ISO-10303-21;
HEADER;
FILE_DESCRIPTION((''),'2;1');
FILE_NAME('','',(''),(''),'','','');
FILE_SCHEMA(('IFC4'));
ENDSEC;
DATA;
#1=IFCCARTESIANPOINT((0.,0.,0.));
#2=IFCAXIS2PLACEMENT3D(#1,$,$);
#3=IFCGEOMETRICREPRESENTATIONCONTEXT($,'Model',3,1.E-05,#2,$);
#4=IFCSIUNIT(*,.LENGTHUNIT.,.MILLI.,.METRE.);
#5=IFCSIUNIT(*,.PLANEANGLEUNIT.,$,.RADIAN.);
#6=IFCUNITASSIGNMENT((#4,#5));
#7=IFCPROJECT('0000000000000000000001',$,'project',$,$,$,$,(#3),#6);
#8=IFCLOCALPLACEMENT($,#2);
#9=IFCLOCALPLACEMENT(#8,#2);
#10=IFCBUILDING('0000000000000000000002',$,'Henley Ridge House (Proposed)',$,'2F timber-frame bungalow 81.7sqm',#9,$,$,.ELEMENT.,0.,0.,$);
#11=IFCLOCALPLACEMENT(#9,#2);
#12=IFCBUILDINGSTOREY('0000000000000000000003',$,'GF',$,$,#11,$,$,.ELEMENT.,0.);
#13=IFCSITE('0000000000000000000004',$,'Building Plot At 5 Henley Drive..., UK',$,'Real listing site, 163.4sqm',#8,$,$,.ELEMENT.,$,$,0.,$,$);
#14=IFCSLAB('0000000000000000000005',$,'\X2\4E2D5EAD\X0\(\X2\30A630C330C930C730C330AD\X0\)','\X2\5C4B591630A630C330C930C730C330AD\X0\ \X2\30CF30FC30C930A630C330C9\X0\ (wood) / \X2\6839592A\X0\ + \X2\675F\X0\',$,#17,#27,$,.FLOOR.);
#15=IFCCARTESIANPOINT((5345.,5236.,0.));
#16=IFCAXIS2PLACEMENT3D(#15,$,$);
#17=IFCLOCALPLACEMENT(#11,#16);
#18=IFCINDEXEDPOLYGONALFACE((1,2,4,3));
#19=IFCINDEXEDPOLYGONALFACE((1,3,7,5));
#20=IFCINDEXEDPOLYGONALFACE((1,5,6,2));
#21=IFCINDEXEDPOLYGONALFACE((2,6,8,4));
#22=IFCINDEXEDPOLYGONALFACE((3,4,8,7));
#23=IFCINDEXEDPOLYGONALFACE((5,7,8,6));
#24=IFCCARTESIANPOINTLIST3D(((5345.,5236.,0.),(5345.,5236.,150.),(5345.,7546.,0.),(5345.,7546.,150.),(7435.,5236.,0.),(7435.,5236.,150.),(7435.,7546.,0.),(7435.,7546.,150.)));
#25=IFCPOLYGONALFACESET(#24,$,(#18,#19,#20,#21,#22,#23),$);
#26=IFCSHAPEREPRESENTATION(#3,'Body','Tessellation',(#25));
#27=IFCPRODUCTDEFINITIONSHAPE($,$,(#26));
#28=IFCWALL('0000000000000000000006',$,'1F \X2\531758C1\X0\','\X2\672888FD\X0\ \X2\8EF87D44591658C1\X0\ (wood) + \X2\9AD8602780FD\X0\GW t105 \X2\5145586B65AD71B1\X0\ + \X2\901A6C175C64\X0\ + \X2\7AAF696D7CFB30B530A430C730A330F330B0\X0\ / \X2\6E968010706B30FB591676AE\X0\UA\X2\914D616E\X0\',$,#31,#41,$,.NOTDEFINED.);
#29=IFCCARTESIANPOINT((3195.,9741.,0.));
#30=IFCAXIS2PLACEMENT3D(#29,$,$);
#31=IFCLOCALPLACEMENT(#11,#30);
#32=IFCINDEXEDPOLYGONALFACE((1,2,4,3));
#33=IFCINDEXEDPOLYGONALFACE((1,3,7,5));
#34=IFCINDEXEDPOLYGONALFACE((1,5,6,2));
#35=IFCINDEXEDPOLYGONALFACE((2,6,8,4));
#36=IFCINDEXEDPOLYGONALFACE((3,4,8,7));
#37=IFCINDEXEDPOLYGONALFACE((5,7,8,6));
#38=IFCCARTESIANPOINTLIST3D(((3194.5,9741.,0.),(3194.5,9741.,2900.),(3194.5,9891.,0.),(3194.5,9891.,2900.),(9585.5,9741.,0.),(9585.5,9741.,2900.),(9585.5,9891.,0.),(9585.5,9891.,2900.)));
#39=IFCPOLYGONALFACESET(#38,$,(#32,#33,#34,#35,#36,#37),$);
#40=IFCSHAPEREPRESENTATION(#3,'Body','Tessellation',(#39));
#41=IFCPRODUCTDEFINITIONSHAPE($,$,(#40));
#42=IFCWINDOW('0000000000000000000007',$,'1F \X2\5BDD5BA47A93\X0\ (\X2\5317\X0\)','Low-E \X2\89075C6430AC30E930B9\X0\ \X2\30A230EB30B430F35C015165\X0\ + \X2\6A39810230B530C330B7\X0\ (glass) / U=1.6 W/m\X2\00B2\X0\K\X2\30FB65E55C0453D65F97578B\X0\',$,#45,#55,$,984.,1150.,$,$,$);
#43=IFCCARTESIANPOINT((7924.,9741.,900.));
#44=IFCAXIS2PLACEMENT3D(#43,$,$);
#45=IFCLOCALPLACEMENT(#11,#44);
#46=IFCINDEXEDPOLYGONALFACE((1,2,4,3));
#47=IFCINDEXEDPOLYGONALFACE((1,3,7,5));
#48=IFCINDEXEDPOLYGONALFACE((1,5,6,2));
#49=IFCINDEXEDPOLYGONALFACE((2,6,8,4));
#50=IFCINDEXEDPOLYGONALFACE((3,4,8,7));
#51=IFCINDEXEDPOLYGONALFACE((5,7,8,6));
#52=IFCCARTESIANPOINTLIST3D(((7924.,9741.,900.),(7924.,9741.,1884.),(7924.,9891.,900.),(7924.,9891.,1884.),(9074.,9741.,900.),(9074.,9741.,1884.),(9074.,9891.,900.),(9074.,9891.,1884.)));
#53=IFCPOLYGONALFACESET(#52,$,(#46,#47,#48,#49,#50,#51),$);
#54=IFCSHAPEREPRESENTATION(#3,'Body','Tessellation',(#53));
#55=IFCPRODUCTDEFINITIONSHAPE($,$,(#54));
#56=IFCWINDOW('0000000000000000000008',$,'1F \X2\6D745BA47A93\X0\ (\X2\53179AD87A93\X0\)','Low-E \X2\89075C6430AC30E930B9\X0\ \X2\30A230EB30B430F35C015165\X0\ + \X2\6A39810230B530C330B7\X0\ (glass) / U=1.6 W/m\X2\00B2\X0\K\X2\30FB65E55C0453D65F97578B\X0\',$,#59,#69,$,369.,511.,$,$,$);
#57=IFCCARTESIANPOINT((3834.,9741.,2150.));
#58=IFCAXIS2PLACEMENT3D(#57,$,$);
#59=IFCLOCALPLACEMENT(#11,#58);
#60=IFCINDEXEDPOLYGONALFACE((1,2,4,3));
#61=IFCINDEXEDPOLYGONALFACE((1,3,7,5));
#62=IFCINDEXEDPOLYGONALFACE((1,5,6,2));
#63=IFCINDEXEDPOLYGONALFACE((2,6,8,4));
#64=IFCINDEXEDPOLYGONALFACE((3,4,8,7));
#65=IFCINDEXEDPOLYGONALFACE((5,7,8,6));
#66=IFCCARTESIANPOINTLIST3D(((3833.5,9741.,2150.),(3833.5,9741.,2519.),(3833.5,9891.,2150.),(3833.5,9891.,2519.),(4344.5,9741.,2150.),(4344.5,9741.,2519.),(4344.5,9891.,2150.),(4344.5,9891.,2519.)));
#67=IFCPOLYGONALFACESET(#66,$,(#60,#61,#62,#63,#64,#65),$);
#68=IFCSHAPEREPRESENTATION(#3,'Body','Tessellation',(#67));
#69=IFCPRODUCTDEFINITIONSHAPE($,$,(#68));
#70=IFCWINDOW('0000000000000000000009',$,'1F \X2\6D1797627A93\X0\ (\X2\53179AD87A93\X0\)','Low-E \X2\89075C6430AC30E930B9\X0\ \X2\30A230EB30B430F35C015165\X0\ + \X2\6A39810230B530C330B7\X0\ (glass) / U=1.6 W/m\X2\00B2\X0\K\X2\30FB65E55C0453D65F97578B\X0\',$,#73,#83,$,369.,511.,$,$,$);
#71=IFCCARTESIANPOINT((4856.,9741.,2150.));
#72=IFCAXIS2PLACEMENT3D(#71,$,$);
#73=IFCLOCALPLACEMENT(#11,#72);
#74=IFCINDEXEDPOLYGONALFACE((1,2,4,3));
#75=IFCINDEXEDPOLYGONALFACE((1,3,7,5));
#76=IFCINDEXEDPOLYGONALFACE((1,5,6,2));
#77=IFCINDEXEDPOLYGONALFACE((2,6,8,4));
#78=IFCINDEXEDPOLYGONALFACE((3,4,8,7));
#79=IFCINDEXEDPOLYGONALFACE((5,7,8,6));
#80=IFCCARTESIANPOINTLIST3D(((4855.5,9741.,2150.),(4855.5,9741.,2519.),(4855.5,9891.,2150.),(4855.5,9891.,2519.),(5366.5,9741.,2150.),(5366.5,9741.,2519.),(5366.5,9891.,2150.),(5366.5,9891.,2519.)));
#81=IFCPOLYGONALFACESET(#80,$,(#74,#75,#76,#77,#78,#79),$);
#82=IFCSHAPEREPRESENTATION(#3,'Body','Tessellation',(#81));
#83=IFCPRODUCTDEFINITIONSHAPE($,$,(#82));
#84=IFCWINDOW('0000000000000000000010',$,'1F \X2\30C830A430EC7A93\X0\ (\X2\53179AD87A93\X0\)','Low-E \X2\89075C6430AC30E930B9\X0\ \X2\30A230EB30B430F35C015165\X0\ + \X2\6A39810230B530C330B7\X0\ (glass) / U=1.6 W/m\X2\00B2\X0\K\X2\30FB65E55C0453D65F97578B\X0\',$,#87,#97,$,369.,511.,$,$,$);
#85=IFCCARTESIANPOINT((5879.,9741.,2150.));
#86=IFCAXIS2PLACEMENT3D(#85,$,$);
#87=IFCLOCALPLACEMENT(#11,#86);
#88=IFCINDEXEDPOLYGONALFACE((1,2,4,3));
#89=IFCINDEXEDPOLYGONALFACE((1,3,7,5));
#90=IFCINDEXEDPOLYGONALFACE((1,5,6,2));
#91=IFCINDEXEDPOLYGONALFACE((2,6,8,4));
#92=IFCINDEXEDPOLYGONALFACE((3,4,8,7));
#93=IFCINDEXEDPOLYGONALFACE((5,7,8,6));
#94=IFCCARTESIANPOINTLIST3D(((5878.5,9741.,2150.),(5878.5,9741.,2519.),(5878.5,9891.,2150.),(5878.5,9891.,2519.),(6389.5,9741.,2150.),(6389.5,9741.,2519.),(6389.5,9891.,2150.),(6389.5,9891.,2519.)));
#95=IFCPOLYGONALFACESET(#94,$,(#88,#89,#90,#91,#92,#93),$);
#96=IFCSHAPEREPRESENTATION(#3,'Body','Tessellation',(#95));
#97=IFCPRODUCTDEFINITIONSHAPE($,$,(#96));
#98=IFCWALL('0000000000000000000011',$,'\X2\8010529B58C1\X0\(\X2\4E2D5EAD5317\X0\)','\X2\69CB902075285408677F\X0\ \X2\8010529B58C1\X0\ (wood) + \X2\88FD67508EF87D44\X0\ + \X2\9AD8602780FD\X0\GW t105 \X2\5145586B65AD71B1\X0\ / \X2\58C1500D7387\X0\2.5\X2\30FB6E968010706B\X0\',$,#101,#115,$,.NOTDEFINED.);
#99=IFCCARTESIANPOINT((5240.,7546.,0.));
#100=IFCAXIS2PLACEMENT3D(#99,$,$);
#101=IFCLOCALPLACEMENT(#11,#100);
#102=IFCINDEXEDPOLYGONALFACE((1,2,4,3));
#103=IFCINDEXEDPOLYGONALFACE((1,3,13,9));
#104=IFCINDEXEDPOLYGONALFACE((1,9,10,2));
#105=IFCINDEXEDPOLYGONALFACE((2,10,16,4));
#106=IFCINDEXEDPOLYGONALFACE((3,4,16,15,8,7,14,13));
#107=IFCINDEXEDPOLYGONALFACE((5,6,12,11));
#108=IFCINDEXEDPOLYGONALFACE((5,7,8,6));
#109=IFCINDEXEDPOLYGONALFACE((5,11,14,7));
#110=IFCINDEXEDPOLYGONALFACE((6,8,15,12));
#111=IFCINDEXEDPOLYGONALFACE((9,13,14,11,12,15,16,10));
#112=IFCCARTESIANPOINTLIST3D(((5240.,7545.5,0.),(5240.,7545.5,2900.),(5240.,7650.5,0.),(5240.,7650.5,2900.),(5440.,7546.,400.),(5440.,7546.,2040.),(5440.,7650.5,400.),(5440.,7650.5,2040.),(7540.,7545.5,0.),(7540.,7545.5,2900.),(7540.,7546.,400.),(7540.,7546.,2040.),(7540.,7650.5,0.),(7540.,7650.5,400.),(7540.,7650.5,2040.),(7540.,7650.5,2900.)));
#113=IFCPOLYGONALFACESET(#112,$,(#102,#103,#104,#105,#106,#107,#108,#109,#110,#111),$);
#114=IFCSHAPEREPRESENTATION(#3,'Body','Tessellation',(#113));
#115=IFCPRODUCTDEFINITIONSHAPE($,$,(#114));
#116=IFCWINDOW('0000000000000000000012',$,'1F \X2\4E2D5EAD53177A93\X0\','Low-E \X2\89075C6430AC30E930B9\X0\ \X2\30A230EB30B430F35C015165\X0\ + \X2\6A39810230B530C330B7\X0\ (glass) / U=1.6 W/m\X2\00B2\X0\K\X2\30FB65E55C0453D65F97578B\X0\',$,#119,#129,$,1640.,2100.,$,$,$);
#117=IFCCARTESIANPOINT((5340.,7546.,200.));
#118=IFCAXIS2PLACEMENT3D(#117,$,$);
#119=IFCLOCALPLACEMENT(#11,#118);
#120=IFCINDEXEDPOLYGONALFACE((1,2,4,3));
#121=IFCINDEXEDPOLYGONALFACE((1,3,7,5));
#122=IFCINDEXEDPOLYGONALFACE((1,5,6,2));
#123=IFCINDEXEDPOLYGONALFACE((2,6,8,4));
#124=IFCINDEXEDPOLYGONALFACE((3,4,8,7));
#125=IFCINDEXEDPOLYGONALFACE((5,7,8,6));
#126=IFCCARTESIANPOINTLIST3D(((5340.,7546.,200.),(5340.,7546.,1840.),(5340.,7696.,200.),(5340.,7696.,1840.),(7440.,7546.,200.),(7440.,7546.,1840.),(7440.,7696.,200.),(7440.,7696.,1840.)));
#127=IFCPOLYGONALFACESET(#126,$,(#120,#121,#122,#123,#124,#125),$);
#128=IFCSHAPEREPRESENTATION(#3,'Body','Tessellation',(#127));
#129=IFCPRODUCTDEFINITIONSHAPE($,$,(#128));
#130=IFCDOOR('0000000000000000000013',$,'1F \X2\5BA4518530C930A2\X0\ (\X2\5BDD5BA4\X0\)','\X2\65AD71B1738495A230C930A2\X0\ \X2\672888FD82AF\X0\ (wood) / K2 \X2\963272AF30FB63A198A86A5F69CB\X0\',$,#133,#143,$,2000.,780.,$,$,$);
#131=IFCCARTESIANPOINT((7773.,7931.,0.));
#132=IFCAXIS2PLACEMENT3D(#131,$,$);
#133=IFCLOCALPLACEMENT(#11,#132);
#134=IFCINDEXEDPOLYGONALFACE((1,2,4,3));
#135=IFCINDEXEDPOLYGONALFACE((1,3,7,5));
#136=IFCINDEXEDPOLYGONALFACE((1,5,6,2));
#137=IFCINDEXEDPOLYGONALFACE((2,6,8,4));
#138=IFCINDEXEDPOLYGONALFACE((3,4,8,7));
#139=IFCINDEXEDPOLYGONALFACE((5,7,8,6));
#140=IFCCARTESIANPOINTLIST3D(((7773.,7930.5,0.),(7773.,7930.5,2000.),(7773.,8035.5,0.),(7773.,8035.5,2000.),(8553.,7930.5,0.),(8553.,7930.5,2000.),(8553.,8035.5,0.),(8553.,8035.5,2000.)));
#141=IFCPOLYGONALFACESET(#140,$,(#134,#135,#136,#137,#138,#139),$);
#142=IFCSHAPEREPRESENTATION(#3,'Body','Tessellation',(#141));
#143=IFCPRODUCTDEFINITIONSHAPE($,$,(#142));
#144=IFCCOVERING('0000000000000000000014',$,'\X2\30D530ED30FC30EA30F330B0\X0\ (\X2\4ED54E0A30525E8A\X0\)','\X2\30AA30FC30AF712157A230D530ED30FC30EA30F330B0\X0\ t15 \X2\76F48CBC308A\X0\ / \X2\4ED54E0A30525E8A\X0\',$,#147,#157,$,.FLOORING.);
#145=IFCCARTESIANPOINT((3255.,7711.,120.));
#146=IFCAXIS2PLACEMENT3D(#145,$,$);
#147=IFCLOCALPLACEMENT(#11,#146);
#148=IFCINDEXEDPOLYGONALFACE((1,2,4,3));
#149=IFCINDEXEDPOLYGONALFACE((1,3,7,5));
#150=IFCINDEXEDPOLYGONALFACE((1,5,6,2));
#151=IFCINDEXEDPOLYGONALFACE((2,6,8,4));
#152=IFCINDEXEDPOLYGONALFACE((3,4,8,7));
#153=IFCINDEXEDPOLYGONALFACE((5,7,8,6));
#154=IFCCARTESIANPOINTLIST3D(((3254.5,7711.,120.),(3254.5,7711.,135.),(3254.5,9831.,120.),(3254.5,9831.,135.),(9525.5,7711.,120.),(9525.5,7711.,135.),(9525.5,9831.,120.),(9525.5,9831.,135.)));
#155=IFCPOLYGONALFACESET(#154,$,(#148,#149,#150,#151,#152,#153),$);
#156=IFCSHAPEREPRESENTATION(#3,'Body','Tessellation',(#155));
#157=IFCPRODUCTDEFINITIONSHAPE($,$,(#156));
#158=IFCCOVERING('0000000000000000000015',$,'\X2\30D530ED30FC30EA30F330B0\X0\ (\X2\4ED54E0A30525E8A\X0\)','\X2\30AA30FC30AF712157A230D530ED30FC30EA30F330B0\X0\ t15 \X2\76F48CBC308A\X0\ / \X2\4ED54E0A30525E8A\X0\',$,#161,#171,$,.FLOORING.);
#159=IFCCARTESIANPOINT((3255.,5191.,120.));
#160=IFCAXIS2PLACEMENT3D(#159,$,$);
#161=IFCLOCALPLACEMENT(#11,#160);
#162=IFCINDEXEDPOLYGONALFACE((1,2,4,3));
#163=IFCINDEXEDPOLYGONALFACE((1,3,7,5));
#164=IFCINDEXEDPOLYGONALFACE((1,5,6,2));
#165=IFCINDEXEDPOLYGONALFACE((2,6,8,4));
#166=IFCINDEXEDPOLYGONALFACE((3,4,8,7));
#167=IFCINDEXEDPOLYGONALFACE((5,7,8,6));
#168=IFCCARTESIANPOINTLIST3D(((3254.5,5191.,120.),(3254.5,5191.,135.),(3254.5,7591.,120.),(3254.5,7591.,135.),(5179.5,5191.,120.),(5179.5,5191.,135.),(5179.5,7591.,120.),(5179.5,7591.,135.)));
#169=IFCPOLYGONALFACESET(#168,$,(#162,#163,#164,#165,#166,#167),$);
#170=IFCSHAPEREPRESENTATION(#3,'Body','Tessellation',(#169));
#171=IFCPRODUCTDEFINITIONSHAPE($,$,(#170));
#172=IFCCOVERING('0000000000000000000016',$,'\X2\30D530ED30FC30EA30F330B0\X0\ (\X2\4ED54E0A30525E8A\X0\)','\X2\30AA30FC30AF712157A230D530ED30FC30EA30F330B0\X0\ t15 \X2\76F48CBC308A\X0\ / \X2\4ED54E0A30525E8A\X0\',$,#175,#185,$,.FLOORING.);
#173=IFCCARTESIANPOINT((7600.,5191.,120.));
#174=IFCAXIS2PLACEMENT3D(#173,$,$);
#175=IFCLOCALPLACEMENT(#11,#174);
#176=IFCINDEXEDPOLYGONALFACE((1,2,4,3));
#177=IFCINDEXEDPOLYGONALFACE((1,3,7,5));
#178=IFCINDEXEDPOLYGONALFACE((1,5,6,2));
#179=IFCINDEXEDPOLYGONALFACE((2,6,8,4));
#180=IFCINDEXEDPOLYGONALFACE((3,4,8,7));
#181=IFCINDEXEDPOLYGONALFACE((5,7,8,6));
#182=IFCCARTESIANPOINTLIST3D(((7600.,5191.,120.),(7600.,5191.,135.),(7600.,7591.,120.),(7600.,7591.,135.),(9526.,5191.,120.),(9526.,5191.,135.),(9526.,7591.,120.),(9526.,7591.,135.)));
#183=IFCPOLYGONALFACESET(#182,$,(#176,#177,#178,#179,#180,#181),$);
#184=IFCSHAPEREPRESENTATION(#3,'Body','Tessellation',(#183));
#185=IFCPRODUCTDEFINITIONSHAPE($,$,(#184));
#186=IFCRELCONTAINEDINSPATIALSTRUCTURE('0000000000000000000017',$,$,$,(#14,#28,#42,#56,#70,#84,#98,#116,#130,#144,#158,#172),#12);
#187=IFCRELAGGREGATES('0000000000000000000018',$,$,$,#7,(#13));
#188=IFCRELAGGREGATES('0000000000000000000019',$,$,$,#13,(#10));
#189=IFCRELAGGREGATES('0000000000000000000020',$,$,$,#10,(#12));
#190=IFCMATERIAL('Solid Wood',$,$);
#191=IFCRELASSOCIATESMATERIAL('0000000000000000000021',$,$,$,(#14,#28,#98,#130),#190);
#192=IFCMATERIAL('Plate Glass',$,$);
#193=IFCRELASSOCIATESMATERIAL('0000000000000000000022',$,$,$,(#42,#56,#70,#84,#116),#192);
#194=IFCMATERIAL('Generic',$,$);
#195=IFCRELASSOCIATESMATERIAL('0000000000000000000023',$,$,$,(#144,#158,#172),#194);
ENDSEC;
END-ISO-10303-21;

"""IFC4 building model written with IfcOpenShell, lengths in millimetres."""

from ifc_helpers import new_model, si_unit, frame, frame_2d, origin, place, context, project, spatial, rectangle, extrude, material, element, fill, save


model = new_model("IFC4")

# Units and contexts
model_context = context("Model", 3, precision=1e-05, world=origin())
ifc_project = project(units=[si_unit("LENGTHUNIT", "METRE", prefix="MILLI"), si_unit("PLANEANGLEUNIT", "RADIAN")], contexts=[model_context])

# Site, building, storey
site_placement = place(None, origin())
site = spatial("IfcSite", under=ifc_project, at=site_placement, Name="Building Plot At 5 Henley Drive..., UK", ObjectType="Real listing site, 163.4sqm", CompositionType="ELEMENT", RefElevation=0.0)
building_placement = place(site_placement, origin())
building = spatial("IfcBuilding", under=site, at=building_placement, Name="Henley Ridge House (Proposed)", ObjectType="2F timber-frame bungalow 81.7sqm", CompositionType="ELEMENT", ElevationOfRefHeight=0.0, ElevationOfTerrain=0.0)
storey_placement = place(building_placement, origin())
storey = spatial("IfcBuildingStorey", under=building, at=storey_placement, Name="GF", CompositionType="ELEMENT", Elevation=0.0)

# Slab
ifc_material_1 = material(Name="Solid Wood")
slab_1_placement = place(storey_placement, frame((5345.0, 5236.0, 0.0)))
element("IfcSlab", 1, at=slab_1_placement, inside=storey, material=ifc_material_1, Name="中庭(ウッドデッキ)", Description="屋外ウッドデッキ ハードウッド (wood) / 根太 + 束", PredefinedType="FLOOR", context=model_context, shape_type="SweptSolid", body=[
    extrude(rectangle(XDim=2090.0, YDim=2310.0, at=frame_2d((1045.0, 1155.0))), frame((5345.0, 5236.0, 0.0)), (0.0, 0.0, 1.0), 150.0),
])

# Wall, openings, windows
wall_1_placement = place(storey_placement, frame((3195.0, 9741.0, 0.0)))
wall_1 = element("IfcWall", 2, at=wall_1_placement, inside=storey, material=ifc_material_1, Name="1F 北壁", Description="木製 軸組外壁 (wood) + 高性能GW t105 充填断熱 + 通気層 + 窯業系サイディング / 準耐火・外皮UA配慮", PredefinedType="NOTDEFINED", context=model_context, shape_type="SweptSolid", body=[
    extrude(rectangle(XDim=6391.0, YDim=150.0, at=frame_2d((3195.0, 75.0))), frame((3195.0, 9741.0, 0.0)), (0.0, 0.0, 1.0), 2900.0),
])
opening_1_placement = place(storey_placement, frame((7924.0, 9741.0, 900.0)))
opening_1 = element("IfcOpeningElement", 3, at=opening_1_placement, cuts=wall_1, PredefinedType="NOTDEFINED", context=model_context, shape_type="SweptSolid", body=[
    extrude(rectangle(XDim=1150.0, YDim=150.0, at=frame_2d((575.0, 75.0))), frame((7924.0, 9741.0, 900.0)), (0.0, 0.0, 1.0), 984.0),
])
opening_2_placement = place(storey_placement, frame((3834.0, 9741.0, 2150.0)))
opening_2 = element("IfcOpeningElement", 4, at=opening_2_placement, cuts=wall_1, PredefinedType="NOTDEFINED", context=model_context, shape_type="SweptSolid", body=[
    extrude(rectangle(XDim=511.0, YDim=150.0, at=frame_2d((255.0, 75.0))), frame((3834.0, 9741.0, 2150.0)), (0.0, 0.0, 1.0), 369.0),
])
opening_3_placement = place(storey_placement, frame((4856.0, 9741.0, 2150.0)))
opening_3 = element("IfcOpeningElement", 5, at=opening_3_placement, cuts=wall_1, PredefinedType="NOTDEFINED", context=model_context, shape_type="SweptSolid", body=[
    extrude(rectangle(XDim=511.0, YDim=150.0, at=frame_2d((255.0, 75.0))), frame((4856.0, 9741.0, 2150.0)), (0.0, 0.0, 1.0), 369.0),
])
opening_4_placement = place(storey_placement, frame((5879.0, 9741.0, 2150.0)))
opening_4 = element("IfcOpeningElement", 6, at=opening_4_placement, cuts=wall_1, PredefinedType="NOTDEFINED", context=model_context, shape_type="SweptSolid", body=[
    extrude(rectangle(XDim=511.0, YDim=150.0, at=frame_2d((255.0, 75.0))), frame((5879.0, 9741.0, 2150.0)), (0.0, 0.0, 1.0), 369.0),
])
ifc_material_2 = material(Name="Plate Glass")
window_1_placement = place(storey_placement, frame((7924.0, 9741.0, 900.0)))
window_1 = element("IfcWindow", 7, at=window_1_placement, inside=storey, material=ifc_material_2, Name="1F 寝室窓 (北)", Description="Low-E 複層ガラス アルゴン封入 + 樹脂サッシ (glass) / U=1.6 W/m²K・日射取得型", OverallHeight=984.0, OverallWidth=1150.0, context=model_context, shape_type="SweptSolid", body=[
    extrude(rectangle(XDim=1150.0, YDim=150.0, at=frame_2d((575.0, 75.0))), frame((7924.0, 9741.0, 900.0)), (0.0, 0.0, 1.0), 984.0),
])
fill(opening_1, window_1)
window_2_placement = place(storey_placement, frame((3834.0, 9741.0, 2150.0)))
window_2 = element("IfcWindow", 8, at=window_2_placement, inside=storey, material=ifc_material_2, Name="1F 浴室窓 (北高窓)", Description="Low-E 複層ガラス アルゴン封入 + 樹脂サッシ (glass) / U=1.6 W/m²K・日射取得型", OverallHeight=369.0, OverallWidth=511.0, context=model_context, shape_type="SweptSolid", body=[
    extrude(rectangle(XDim=511.0, YDim=150.0, at=frame_2d((255.0, 75.0))), frame((3834.0, 9741.0, 2150.0)), (0.0, 0.0, 1.0), 369.0),
])
fill(opening_2, window_2)
window_3_placement = place(storey_placement, frame((4856.0, 9741.0, 2150.0)))
window_3 = element("IfcWindow", 9, at=window_3_placement, inside=storey, material=ifc_material_2, Name="1F 洗面窓 (北高窓)", Description="Low-E 複層ガラス アルゴン封入 + 樹脂サッシ (glass) / U=1.6 W/m²K・日射取得型", OverallHeight=369.0, OverallWidth=511.0, context=model_context, shape_type="SweptSolid", body=[
    extrude(rectangle(XDim=511.0, YDim=150.0, at=frame_2d((255.0, 75.0))), frame((4856.0, 9741.0, 2150.0)), (0.0, 0.0, 1.0), 369.0),
])
fill(opening_3, window_3)
window_4_placement = place(storey_placement, frame((5879.0, 9741.0, 2150.0)))
window_4 = element("IfcWindow", 10, at=window_4_placement, inside=storey, material=ifc_material_2, Name="1F トイレ窓 (北高窓)", Description="Low-E 複層ガラス アルゴン封入 + 樹脂サッシ (glass) / U=1.6 W/m²K・日射取得型", OverallHeight=369.0, OverallWidth=511.0, context=model_context, shape_type="SweptSolid", body=[
    extrude(rectangle(XDim=511.0, YDim=150.0, at=frame_2d((255.0, 75.0))), frame((5879.0, 9741.0, 2150.0)), (0.0, 0.0, 1.0), 369.0),
])
fill(opening_4, window_4)

# Wall, opening, window
wall_2_placement = place(storey_placement, frame((5240.0, 7546.0, 0.0)))
wall_2 = element("IfcWall", 11, at=wall_2_placement, inside=storey, material=ifc_material_1, Name="耐力壁(中庭北)", Description="構造用合板 耐力壁 (wood) + 製材軸組 + 高性能GW t105 充填断熱 / 壁倍率2.5・準耐火", PredefinedType="NOTDEFINED", context=model_context, shape_type="SweptSolid", body=[
    extrude(rectangle(XDim=2300.0, YDim=105.0, at=frame_2d((1150.0, 52.0))), frame((5240.0, 7546.0, 0.0)), (0.0, 0.0, 1.0), 2900.0),
])
opening_5_placement = place(storey_placement, frame((5340.0, 7546.0, 200.0)))
opening_5 = element("IfcOpeningElement", 12, at=opening_5_placement, cuts=wall_2, PredefinedType="NOTDEFINED", context=model_context, shape_type="SweptSolid", body=[
    extrude(rectangle(XDim=2100.0, YDim=150.0, at=frame_2d((1050.0, 75.0))), frame((5340.0, 7546.0, 200.0)), (0.0, 0.0, 1.0), 1640.0),
])
window_5_placement = place(storey_placement, frame((5340.0, 7546.0, 200.0)))
window_5 = element("IfcWindow", 13, at=window_5_placement, inside=storey, material=ifc_material_2, Name="1F 中庭北窓", Description="Low-E 複層ガラス アルゴン封入 + 樹脂サッシ (glass) / U=1.6 W/m²K・日射取得型", OverallHeight=1640.0, OverallWidth=2100.0, context=model_context, shape_type="SweptSolid", body=[
    extrude(rectangle(XDim=2100.0, YDim=150.0, at=frame_2d((1050.0, 75.0))), frame((5340.0, 7546.0, 200.0)), (0.0, 0.0, 1.0), 1640.0),
])
fill(opening_5, window_5)

# Door
door_1_placement = place(storey_placement, frame((7773.0, 7931.0, 0.0)))
element("IfcDoor", 14, at=door_1_placement, inside=storey, material=ifc_material_1, Name="1F 室内ドア (寝室)", Description="断熱玄関ドア 木製芯 (wood) / K2 防犯・採風機構", OverallHeight=2000.0, OverallWidth=780.0, context=model_context, shape_type="SweptSolid", body=[
    extrude(rectangle(XDim=780.0, YDim=105.0, at=frame_2d((390.0, 52.0))), frame((7773.0, 7931.0, 0.0)), (0.0, 0.0, 1.0), 2000.0),
])

# Coverings
ifc_material_3 = material(Name="Generic")
covering_1_placement = place(storey_placement, frame((3255.0, 7711.0, 120.0)))
element("IfcCovering", 15, at=covering_1_placement, inside=storey, material=ifc_material_3, Name="フローリング (仕上げ床)", Description="オーク無垢フローリング t15 直貼り / 仕上げ床", PredefinedType="FLOORING", context=model_context, shape_type="SweptSolid", body=[
    extrude(rectangle(XDim=6271.0, YDim=2120.0, at=frame_2d((3135.0, 1060.0))), frame((3255.0, 7711.0, 120.0)), (0.0, 0.0, 1.0), 15.0),
])
covering_2_placement = place(storey_placement, frame((3255.0, 5191.0, 120.0)))
element("IfcCovering", 16, at=covering_2_placement, inside=storey, material=ifc_material_3, Name="フローリング (仕上げ床)", Description="オーク無垢フローリング t15 直貼り / 仕上げ床", PredefinedType="FLOORING", context=model_context, shape_type="SweptSolid", body=[
    extrude(rectangle(XDim=1925.0, YDim=2400.0, at=frame_2d((962.0, 1200.0))), frame((3255.0, 5191.0, 120.0)), (0.0, 0.0, 1.0), 15.0),
])
covering_3_placement = place(storey_placement, frame((7600.0, 5191.0, 120.0)))
element("IfcCovering", 17, at=covering_3_placement, inside=storey, material=ifc_material_3, Name="フローリング (仕上げ床)", Description="オーク無垢フローリング t15 直貼り / 仕上げ床", PredefinedType="FLOORING", context=model_context, shape_type="SweptSolid", body=[
    extrude(rectangle(XDim=1926.0, YDim=2400.0, at=frame_2d((963.0, 1200.0))), frame((7600.0, 5191.0, 120.0)), (0.0, 0.0, 1.0), 15.0),
])

save(model, "model.ifc")
